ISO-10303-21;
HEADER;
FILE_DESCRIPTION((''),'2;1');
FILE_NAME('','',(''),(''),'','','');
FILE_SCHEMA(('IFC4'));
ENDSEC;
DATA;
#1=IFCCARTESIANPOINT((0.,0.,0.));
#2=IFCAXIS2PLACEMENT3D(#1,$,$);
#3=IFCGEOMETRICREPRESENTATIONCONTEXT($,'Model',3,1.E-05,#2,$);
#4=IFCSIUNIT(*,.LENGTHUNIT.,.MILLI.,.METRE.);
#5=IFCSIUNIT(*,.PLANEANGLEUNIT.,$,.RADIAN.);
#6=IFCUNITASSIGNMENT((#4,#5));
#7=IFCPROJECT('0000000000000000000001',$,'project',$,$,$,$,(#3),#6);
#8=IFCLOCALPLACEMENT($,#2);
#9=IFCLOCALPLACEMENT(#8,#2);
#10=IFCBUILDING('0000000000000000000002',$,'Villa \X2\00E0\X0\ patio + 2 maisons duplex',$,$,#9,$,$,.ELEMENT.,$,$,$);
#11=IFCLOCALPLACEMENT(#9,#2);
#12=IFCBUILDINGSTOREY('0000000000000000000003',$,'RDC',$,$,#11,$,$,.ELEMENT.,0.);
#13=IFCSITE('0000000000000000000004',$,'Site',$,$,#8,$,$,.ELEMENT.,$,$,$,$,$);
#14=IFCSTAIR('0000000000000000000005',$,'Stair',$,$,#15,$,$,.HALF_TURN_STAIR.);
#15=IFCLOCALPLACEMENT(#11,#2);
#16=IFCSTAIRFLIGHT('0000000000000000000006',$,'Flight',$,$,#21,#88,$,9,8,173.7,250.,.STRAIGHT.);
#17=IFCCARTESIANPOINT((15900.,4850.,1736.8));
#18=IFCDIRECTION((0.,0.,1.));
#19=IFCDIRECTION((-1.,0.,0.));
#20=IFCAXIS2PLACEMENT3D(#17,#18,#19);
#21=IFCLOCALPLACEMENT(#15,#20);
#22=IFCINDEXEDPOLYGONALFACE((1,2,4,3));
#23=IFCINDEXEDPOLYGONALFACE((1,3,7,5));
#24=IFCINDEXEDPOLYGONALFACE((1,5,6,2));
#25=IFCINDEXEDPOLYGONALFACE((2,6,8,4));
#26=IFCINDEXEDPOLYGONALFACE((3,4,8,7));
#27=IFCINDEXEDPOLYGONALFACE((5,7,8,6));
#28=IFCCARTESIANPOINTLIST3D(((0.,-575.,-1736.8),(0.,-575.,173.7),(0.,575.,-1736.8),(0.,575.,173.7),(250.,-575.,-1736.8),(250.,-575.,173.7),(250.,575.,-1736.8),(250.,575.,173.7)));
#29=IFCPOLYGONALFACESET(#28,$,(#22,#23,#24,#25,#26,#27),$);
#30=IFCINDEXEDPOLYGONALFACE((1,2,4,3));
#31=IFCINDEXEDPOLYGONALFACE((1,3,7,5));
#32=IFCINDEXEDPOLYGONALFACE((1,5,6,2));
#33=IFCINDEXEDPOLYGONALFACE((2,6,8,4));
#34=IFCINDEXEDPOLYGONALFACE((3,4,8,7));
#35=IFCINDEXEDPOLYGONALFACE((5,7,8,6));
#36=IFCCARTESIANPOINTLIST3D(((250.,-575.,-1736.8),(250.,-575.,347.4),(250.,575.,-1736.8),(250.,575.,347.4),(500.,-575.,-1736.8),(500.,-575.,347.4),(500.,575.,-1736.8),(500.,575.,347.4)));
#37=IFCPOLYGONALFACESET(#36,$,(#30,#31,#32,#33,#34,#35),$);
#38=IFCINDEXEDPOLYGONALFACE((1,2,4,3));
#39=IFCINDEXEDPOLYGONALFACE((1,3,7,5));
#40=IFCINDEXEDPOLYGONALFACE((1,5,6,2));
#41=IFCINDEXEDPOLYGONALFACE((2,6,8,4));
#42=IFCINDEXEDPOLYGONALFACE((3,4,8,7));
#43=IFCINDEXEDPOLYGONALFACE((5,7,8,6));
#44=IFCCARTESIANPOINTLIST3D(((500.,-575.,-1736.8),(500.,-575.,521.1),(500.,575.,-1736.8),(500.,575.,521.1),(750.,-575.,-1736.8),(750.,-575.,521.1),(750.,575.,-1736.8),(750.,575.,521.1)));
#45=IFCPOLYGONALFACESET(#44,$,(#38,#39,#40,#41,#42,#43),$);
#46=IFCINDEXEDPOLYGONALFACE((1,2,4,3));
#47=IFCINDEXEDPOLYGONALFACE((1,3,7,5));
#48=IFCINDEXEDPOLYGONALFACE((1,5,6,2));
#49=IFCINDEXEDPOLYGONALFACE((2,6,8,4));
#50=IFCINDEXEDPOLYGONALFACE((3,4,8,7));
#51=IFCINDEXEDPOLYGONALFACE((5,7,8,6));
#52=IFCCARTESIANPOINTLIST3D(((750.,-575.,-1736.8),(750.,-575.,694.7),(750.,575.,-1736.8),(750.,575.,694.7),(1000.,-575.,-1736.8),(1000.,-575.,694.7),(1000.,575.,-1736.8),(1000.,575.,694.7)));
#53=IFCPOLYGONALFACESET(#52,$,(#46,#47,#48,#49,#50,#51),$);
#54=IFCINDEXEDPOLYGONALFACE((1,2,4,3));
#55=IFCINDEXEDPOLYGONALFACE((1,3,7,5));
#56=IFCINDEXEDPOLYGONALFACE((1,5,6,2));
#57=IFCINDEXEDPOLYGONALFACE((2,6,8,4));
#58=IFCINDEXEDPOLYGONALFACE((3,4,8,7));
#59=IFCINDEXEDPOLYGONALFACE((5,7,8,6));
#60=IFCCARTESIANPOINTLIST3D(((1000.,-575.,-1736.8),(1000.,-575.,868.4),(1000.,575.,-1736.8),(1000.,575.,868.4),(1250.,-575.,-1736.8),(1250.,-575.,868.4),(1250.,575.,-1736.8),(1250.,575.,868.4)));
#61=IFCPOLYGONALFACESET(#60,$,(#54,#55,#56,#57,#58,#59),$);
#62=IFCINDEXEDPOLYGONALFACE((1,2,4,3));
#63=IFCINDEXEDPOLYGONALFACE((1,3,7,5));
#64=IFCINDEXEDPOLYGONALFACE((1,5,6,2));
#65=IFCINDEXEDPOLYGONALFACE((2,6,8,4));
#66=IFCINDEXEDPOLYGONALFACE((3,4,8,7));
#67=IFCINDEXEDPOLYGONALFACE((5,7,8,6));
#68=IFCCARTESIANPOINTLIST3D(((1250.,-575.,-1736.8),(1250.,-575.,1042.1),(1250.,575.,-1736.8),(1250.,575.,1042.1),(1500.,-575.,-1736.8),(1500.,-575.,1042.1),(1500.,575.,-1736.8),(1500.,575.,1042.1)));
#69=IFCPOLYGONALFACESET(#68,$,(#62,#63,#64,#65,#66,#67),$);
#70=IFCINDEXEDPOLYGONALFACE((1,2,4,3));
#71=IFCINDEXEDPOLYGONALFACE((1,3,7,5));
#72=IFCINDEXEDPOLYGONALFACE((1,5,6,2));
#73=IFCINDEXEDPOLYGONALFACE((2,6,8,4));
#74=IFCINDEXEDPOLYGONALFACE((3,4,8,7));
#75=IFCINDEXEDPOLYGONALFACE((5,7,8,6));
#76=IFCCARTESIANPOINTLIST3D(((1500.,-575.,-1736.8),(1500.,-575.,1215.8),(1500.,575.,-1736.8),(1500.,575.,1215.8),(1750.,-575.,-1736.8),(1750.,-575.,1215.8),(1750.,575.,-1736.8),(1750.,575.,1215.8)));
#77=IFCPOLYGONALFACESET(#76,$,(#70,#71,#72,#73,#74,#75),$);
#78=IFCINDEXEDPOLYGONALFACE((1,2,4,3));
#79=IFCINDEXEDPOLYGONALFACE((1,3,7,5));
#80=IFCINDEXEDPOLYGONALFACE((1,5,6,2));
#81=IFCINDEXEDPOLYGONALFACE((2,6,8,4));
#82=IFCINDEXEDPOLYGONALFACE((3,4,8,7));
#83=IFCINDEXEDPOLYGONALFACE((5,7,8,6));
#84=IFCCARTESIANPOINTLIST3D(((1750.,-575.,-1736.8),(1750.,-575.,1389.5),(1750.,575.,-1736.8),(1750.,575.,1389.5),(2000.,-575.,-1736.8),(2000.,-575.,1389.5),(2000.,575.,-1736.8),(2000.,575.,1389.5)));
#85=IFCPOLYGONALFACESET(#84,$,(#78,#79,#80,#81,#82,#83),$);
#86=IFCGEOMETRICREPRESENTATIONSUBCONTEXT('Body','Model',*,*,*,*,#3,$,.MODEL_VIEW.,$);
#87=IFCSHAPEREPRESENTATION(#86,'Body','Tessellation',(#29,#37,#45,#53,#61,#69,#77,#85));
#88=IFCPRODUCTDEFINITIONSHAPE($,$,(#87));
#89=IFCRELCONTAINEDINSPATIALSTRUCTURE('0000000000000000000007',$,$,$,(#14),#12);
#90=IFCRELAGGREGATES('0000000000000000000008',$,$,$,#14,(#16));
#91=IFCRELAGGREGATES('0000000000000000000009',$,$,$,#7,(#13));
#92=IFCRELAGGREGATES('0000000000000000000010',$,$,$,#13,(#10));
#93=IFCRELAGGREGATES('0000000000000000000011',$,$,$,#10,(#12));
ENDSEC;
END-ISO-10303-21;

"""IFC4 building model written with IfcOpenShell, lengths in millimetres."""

from ifc_helpers import new_model, si_unit, frame, frame_2d, origin, place, context, subcontext, project, spatial, rectangle, extrude, element, aggregate, save


model = new_model("IFC4")

# Units and contexts
model_context = context("Model", 3, precision=1e-05, world=origin())
body_context = subcontext(model_context, "Body", "Model", "MODEL_VIEW")
ifc_project = project(units=[si_unit("LENGTHUNIT", "METRE", prefix="MILLI"), si_unit("PLANEANGLEUNIT", "RADIAN")], contexts=[model_context])

# Site, building, storey
site_placement = place(None, origin())
site = spatial("IfcSite", under=ifc_project, at=site_placement, Name="Site", CompositionType="ELEMENT")
building_placement = place(site_placement, origin())
building = spatial("IfcBuilding", under=site, at=building_placement, Name="Villa à patio + 2 maisons duplex", CompositionType="ELEMENT")
storey_placement = place(building_placement, origin())
storey = spatial("IfcBuildingStorey", under=building, at=storey_placement, Name="RDC", CompositionType="ELEMENT", Elevation=0.0)

# Stair, stair flight
stair_placement = place(storey_placement, origin())
stair = element("IfcStair", 1, at=stair_placement, inside=storey, Name="Stair", PredefinedType="HALF_TURN_STAIR")
stair_flight_1_placement = place(stair_placement, frame((15900.0, 4850.0, 1736.8), z_axis=(0.0, 0.0, 1.0), x_axis=(-1.0, 0.0, 0.0)))
stair_flight_1 = element("IfcStairFlight", 2, at=stair_flight_1_placement, Name="Flight", NumberOfRisers=9, NumberOfTreads=8, PredefinedType="STRAIGHT", RiserHeight=173.7, TreadLength=250.0, context=body_context, shape_type="SweptSolid", body=[
    extrude(rectangle(XDim=250.0, YDim=1150.0, at=frame_2d((125.0, 0.0))), frame((0.0, 0.0, -1736.8)), (0.0, 0.0, 1.0), 1910.5),
    extrude(rectangle(XDim=250.0, YDim=1150.0, at=frame_2d((375.0, 0.0))), frame((0.0, 0.0, -1736.8)), (0.0, 0.0, 1.0), 2084.2),
    extrude(rectangle(XDim=250.0, YDim=1150.0, at=frame_2d((625.0, 0.0))), frame((0.0, 0.0, -1736.8)), (0.0, 0.0, 1.0), 2257.9),
    extrude(rectangle(XDim=250.0, YDim=1150.0, at=frame_2d((875.0, 0.0))), frame((0.0, 0.0, -1736.8)), (0.0, 0.0, 1.0), 2431.6),
    extrude(rectangle(XDim=250.0, YDim=1150.0, at=frame_2d((1125.0, 0.0))), frame((0.0, 0.0, -1736.8)), (0.0, 0.0, 1.0), 2605.3),
    extrude(rectangle(XDim=250.0, YDim=1150.0, at=frame_2d((1375.0, 0.0))), frame((0.0, 0.0, -1736.8)), (0.0, 0.0, 1.0), 2778.9),
    extrude(rectangle(XDim=250.0, YDim=1150.0, at=frame_2d((1625.0, 0.0))), frame((0.0, 0.0, -1736.8)), (0.0, 0.0, 1.0), 2952.6),
    extrude(rectangle(XDim=250.0, YDim=1150.0, at=frame_2d((1875.0, 0.0))), frame((0.0, 0.0, -1736.8)), (0.0, 0.0, 1.0), 3126.3),
])
aggregate(stair, [stair_flight_1])

save(model, "model.ifc")
